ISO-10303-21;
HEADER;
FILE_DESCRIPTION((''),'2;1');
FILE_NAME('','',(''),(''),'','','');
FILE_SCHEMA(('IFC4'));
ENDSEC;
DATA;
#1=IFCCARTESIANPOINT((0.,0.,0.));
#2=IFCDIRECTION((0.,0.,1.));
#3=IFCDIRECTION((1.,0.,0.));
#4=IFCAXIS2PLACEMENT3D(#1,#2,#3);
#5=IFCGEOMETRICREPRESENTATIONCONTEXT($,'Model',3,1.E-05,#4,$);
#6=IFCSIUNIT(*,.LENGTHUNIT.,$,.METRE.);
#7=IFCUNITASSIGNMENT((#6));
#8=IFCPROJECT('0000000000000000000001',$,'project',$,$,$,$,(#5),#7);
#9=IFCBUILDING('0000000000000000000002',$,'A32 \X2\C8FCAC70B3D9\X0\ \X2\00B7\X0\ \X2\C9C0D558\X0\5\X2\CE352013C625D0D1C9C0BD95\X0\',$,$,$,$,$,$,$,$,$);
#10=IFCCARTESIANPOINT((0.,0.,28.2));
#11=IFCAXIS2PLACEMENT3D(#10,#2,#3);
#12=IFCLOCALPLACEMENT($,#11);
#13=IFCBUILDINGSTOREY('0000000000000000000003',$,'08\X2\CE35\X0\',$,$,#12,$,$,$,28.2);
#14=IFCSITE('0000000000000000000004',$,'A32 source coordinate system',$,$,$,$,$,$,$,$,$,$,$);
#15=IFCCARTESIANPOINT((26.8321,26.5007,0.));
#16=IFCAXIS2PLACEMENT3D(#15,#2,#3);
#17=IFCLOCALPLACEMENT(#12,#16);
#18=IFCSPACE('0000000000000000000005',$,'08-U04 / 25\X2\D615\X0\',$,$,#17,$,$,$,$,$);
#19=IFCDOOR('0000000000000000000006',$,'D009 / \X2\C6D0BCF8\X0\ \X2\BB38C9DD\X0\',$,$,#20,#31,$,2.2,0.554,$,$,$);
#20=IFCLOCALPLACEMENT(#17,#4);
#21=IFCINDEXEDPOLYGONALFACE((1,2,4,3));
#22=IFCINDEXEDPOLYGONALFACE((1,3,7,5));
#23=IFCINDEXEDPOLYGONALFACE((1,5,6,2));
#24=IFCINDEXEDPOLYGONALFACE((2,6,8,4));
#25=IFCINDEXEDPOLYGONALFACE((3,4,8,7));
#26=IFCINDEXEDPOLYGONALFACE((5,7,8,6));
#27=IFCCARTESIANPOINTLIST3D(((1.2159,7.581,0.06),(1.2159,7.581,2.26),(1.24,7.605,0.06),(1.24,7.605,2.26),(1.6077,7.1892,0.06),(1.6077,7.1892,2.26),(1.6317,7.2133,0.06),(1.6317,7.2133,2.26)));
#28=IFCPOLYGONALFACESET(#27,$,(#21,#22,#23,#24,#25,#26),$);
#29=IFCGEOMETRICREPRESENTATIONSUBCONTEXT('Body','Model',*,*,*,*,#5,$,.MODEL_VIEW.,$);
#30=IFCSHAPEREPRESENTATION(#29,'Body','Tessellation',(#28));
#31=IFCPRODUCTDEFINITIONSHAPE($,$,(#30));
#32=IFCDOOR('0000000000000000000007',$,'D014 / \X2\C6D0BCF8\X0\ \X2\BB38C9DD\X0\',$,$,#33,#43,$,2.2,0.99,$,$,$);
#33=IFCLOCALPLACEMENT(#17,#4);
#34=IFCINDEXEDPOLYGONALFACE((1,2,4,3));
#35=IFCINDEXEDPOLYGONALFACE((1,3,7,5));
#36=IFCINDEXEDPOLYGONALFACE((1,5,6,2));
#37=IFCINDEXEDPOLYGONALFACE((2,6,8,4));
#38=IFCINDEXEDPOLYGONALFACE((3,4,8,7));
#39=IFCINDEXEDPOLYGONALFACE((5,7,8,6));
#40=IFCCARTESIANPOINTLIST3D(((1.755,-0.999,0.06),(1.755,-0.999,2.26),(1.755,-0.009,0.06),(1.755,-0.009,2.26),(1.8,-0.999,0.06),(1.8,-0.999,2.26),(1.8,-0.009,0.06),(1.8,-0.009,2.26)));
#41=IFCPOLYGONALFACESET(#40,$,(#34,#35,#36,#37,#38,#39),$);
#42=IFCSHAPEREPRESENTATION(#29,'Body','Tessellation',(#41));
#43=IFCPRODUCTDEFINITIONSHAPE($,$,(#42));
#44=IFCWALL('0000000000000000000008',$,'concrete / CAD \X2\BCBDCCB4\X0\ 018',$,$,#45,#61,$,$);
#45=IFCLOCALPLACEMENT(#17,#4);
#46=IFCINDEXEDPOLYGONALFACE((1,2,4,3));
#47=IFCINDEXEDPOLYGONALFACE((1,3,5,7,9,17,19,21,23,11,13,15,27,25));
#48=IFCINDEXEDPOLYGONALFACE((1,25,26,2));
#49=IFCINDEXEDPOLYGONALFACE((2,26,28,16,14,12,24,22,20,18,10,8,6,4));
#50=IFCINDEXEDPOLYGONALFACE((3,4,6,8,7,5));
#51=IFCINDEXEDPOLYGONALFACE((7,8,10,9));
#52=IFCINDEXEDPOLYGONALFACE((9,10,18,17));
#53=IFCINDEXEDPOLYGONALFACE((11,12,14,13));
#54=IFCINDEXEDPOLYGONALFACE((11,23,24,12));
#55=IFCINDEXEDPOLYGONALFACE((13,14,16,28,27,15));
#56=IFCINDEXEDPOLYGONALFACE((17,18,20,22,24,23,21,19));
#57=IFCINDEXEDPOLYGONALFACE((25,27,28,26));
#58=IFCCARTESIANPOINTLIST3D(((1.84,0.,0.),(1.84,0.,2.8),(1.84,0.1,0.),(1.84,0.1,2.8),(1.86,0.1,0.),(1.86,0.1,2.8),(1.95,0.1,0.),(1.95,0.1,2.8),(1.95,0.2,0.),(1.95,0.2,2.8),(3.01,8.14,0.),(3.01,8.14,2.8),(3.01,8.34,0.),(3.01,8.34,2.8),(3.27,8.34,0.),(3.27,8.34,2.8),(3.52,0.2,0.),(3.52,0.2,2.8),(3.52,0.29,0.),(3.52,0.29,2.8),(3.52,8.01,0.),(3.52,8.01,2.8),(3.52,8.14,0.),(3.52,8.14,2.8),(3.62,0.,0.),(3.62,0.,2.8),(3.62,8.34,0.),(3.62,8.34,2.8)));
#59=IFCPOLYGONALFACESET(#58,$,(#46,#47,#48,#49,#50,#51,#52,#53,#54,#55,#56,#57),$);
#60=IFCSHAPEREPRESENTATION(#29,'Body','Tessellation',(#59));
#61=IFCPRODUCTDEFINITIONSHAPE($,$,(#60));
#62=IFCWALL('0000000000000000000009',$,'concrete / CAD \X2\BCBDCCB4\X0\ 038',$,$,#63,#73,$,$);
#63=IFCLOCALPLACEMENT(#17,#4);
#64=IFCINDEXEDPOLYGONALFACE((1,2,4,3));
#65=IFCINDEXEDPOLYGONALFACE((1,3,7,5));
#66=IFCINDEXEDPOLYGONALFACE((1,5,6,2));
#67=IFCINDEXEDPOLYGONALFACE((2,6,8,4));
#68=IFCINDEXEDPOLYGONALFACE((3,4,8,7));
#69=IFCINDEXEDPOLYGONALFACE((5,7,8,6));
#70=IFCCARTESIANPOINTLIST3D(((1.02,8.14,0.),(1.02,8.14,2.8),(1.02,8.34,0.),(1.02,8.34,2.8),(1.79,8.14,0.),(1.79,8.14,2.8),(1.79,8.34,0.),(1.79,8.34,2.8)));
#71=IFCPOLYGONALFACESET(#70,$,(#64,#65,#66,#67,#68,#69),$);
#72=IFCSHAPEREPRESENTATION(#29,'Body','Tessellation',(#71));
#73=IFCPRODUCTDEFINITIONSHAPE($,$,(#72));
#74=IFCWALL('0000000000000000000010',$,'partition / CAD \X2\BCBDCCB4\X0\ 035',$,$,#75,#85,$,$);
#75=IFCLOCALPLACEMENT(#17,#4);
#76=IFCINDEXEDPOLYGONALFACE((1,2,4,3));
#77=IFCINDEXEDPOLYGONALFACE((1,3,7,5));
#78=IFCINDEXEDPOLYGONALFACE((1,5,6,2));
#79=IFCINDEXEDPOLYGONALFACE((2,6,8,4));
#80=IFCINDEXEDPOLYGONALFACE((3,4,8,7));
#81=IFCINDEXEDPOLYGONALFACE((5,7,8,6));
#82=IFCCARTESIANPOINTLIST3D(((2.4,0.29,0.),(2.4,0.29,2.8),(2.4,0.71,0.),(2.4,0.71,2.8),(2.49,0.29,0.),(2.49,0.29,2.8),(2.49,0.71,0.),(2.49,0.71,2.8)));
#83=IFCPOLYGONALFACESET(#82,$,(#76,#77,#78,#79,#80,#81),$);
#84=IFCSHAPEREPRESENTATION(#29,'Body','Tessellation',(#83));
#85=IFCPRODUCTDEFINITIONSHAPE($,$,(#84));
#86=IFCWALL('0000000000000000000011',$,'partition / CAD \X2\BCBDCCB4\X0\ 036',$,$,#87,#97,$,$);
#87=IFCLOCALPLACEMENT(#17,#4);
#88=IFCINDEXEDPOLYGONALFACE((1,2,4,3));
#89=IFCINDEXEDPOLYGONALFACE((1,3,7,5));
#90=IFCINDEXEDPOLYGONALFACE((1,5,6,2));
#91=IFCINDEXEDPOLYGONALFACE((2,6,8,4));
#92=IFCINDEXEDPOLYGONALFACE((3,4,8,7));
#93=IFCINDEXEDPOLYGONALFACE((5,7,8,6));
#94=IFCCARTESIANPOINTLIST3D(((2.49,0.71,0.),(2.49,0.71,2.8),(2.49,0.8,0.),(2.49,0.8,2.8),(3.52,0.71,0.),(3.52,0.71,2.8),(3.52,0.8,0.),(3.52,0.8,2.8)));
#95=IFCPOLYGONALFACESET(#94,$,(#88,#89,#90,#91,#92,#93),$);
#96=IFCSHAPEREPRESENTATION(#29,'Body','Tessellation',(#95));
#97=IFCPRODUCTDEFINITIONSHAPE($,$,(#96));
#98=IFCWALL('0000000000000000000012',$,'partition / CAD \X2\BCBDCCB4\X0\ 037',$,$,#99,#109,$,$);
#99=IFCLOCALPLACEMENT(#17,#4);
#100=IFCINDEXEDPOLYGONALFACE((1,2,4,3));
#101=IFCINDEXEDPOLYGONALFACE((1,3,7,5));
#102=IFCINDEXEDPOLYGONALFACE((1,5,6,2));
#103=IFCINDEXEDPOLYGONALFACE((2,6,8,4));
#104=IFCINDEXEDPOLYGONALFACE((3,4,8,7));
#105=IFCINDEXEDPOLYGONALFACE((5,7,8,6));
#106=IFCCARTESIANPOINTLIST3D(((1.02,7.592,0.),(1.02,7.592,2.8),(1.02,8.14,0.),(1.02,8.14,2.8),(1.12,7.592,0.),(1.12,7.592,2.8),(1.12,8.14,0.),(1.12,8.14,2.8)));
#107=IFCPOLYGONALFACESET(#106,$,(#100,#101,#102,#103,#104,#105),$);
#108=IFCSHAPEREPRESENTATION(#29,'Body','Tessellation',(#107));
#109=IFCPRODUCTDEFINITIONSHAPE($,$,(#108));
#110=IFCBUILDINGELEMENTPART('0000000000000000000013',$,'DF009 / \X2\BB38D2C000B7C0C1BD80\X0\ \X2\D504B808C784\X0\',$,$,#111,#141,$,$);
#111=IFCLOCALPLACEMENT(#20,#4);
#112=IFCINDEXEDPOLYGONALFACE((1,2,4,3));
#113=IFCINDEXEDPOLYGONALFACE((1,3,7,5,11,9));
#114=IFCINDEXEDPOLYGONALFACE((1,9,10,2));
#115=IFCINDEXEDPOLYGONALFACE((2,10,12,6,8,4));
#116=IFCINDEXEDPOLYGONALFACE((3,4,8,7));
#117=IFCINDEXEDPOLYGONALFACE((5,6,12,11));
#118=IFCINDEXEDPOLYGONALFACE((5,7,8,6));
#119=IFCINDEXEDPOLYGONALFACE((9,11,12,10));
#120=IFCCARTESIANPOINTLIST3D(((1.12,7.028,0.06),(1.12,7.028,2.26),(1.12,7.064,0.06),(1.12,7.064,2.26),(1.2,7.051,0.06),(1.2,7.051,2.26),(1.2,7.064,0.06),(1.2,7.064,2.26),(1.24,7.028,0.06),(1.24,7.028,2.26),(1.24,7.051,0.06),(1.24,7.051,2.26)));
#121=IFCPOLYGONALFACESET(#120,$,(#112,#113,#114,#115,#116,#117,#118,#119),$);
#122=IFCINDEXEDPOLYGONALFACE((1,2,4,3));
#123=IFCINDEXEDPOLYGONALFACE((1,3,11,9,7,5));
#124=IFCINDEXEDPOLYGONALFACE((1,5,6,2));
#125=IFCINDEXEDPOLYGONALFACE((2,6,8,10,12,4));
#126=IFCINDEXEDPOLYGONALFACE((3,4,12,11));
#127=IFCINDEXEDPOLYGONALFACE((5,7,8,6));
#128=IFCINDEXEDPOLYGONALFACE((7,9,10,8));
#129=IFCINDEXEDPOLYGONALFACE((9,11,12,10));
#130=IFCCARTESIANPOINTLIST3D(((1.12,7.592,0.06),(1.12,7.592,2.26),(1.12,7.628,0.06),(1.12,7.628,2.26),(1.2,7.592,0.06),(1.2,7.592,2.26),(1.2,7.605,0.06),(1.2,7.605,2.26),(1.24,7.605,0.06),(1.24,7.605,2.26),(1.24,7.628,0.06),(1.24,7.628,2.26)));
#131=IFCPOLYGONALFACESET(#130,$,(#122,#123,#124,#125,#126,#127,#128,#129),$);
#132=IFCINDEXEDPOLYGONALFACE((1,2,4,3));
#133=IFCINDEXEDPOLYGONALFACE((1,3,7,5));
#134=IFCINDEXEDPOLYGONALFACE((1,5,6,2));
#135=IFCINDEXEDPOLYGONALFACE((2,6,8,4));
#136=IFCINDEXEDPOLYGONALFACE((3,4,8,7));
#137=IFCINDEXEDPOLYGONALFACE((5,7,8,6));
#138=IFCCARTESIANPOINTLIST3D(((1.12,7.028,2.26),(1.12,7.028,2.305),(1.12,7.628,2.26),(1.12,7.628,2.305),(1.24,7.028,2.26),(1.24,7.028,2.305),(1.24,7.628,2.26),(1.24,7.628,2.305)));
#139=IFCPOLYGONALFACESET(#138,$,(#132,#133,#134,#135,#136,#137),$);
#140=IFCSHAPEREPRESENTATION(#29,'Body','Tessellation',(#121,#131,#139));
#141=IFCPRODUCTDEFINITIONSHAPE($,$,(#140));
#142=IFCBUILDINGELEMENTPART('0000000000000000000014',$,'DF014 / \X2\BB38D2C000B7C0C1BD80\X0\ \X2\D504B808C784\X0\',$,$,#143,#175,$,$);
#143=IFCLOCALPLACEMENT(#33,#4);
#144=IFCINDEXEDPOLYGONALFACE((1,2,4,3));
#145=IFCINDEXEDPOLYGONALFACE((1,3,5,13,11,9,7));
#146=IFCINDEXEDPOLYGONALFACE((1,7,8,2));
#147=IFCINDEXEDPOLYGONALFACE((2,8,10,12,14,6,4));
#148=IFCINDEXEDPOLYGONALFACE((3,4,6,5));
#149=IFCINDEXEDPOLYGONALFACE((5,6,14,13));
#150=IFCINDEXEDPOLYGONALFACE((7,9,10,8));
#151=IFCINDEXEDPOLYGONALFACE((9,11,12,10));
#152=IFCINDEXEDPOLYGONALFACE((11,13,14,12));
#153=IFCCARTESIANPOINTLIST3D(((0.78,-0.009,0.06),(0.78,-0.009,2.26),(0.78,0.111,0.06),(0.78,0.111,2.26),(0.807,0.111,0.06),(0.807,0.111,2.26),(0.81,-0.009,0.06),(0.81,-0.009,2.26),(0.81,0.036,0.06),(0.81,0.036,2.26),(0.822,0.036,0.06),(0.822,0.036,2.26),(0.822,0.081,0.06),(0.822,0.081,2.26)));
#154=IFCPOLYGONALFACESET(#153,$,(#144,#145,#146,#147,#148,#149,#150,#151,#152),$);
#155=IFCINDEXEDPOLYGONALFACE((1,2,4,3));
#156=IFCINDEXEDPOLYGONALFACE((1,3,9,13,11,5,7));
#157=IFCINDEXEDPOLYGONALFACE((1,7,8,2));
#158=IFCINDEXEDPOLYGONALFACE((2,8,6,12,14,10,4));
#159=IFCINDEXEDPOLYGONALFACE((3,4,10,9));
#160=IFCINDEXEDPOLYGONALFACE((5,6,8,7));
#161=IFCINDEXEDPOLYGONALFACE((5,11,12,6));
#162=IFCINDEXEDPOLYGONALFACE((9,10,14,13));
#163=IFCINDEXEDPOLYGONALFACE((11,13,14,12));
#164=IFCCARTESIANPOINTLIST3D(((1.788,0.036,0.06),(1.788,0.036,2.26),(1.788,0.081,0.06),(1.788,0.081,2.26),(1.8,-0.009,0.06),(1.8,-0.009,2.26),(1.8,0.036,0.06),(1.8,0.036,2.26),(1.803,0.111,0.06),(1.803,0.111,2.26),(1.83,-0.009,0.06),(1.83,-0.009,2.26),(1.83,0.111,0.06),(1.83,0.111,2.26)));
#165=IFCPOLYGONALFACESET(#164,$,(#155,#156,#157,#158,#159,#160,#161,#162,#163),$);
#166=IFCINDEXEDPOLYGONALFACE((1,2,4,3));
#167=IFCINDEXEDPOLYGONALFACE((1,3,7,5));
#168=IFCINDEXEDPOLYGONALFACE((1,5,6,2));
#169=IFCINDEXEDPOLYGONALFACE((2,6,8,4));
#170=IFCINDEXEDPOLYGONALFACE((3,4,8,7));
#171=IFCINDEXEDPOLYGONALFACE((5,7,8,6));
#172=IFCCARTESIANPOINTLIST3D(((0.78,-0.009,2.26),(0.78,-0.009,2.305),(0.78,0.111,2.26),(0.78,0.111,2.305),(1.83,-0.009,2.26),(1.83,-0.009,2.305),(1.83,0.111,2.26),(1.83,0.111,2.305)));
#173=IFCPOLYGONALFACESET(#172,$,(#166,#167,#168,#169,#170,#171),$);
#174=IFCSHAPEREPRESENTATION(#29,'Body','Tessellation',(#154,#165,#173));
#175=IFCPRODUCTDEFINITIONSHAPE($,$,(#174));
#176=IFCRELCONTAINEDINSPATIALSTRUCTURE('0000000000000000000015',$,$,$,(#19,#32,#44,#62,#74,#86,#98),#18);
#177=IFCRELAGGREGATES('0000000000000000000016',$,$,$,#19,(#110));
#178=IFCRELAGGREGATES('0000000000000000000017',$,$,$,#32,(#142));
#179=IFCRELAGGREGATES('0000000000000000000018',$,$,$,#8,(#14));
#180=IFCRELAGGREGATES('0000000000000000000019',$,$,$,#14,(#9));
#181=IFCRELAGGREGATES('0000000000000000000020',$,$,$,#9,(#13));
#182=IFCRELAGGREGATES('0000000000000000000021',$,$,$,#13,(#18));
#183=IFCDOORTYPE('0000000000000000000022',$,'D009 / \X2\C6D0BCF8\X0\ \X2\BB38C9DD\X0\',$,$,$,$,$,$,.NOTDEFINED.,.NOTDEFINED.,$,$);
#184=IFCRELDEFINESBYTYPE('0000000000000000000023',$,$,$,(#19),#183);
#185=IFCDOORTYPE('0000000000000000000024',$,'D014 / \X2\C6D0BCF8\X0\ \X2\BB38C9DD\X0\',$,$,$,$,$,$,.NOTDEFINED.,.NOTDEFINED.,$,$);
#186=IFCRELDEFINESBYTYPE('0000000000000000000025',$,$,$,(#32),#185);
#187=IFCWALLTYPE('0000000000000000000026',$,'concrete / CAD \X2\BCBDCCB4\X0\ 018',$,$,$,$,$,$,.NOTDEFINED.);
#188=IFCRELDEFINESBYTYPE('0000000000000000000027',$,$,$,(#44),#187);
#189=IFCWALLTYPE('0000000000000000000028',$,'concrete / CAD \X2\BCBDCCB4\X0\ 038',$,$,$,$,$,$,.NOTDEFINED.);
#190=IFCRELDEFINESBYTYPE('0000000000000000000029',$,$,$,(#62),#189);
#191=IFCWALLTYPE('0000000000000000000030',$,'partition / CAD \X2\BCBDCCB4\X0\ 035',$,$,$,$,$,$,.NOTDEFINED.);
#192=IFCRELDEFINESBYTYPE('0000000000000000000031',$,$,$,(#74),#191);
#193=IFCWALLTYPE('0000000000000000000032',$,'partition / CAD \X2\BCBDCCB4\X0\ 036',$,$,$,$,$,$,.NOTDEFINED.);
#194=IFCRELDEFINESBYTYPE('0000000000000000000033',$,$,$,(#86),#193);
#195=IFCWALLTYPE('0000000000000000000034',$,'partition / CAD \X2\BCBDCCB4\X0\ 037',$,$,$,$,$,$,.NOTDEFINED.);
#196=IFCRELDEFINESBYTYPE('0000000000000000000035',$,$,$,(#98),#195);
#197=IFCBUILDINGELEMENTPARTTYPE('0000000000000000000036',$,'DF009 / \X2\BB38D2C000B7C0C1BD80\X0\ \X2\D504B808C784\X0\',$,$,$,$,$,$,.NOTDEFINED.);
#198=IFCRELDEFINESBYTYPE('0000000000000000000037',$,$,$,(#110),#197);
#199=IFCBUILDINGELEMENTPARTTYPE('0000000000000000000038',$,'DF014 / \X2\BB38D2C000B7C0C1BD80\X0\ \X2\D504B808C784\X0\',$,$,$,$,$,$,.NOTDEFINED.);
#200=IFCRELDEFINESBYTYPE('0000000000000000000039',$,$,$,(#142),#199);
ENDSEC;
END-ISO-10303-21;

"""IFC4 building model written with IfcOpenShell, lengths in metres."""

from ifc_helpers import new_model, si_unit, frame, origin, origin_with_axes, place, context, subcontext, project, spatial, polyline, outline, extrude, source, transform, mapped, type_object, type_shapes, element, aggregate, save


model = new_model("IFC4")

# Units and contexts
model_context = context("Model", 3, precision=1e-05, world=origin_with_axes())
body_context = subcontext(model_context, "Body", "Model", "MODEL_VIEW")
ifc_project = project(units=[si_unit("LENGTHUNIT", "METRE")], contexts=[model_context])

# Site, building, storey, space
storey_placement = place(None, frame((0.0, 0.0, 28.2), z_axis=(0.0, 0.0, 1.0), x_axis=(1.0, 0.0, 0.0)))
space_placement = place(storey_placement, frame((26.8321, 26.5007, 0.0), z_axis=(0.0, 0.0, 1.0), x_axis=(1.0, 0.0, 0.0)))
site = spatial("IfcSite", under=ifc_project, Name="A32 source coordinate system")
building = spatial("IfcBuilding", under=site, Name="A32 주거동 · 지하5층–옥탑지붕")
storey = spatial("IfcBuildingStorey", under=building, at=storey_placement, Name="08층", Elevation=28.2)
space = spatial("IfcSpace", under=storey, at=space_placement, Name="08-U04 / 25형")

# Doors
door_type_1 = type_object("IfcDoorType", Name="D009 / 원본 문짝", OperationType="NOTDEFINED", PredefinedType="NOTDEFINED")
shared_shape_1 = source(origin(), body_context, "Body", "SweptSolid", [
    extrude(outline(polyline([(1.24, 7.605), (1.6317, 7.2133), (1.6077, 7.1892), (1.2159, 7.581), (1.24, 7.605)])), frame((0.0, 0.0, 0.06)), (0.0, 0.0, 1.0), 2.2),
])
type_shapes(door_type_1, [shared_shape_1])
door_1_placement = place(space_placement, origin_with_axes())
door_1 = element("IfcDoor", 1, at=door_1_placement, inside=space, type_object=door_type_1, Name="D009 / 원본 문짝", OverallHeight=2.2, OverallWidth=0.554, context=body_context, shape_type="MappedRepresentation", body=[
    mapped(shared_shape_1, transform((0.0, 0.0, 0.0), scale=1.0)),
])
door_type_2 = type_object("IfcDoorType", Name="D014 / 원본 문짝", OperationType="NOTDEFINED", PredefinedType="NOTDEFINED")
shared_shape_2 = source(origin(), body_context, "Body", "SweptSolid", [
    extrude(outline(polyline([(1.8, -0.009), (1.8, -0.999), (1.755, -0.999), (1.755, -0.009), (1.8, -0.009)])), frame((0.0, 0.0, 0.06)), (0.0, 0.0, 1.0), 2.2),
])
type_shapes(door_type_2, [shared_shape_2])
door_2_placement = place(space_placement, origin_with_axes())
door_2 = element("IfcDoor", 2, at=door_2_placement, inside=space, type_object=door_type_2, Name="D014 / 원본 문짝", OverallHeight=2.2, OverallWidth=0.99, context=body_context, shape_type="MappedRepresentation", body=[
    mapped(shared_shape_2, transform((0.0, 0.0, 0.0), scale=1.0)),
])

# Walls
wall_type_1 = type_object("IfcWallType", Name="concrete / CAD 벽체 018", PredefinedType="NOTDEFINED")
shared_shape_3 = source(origin(), body_context, "Body", "SweptSolid", [
    extrude(outline(polyline([(3.27, 8.34), (3.27, 8.34), (3.62, 8.34), (3.62, 0.0), (1.84, 0.0), (1.84, 0.1), (1.86, 0.1), (1.95, 0.1), (1.95, 0.2), (3.52, 0.2), (3.52, 0.29), (3.52, 8.01), (3.52, 8.14), (3.01, 8.14), (3.01, 8.34), (3.27, 8.34)])), origin(), (0.0, 0.0, 1.0), 2.8),
])
type_shapes(wall_type_1, [shared_shape_3])
wall_1_placement = place(space_placement, origin_with_axes())
element("IfcWall", 3, at=wall_1_placement, inside=space, type_object=wall_type_1, Name="concrete / CAD 벽체 018", context=body_context, shape_type="MappedRepresentation", body=[
    mapped(shared_shape_3, transform((0.0, 0.0, 0.0), scale=1.0)),
])
wall_type_2 = type_object("IfcWallType", Name="concrete / CAD 벽체 038", PredefinedType="NOTDEFINED")
shared_shape_4 = source(origin(), body_context, "Body", "SweptSolid", [
    extrude(outline(polyline([(1.02, 8.14), (1.02, 8.34), (1.79, 8.34), (1.79, 8.14), (1.02, 8.14)])), origin(), (0.0, 0.0, 1.0), 2.8),
])
type_shapes(wall_type_2, [shared_shape_4])
wall_2_placement = place(space_placement, origin_with_axes())
element("IfcWall", 4, at=wall_2_placement, inside=space, type_object=wall_type_2, Name="concrete / CAD 벽체 038", context=body_context, shape_type="MappedRepresentation", body=[
    mapped(shared_shape_4, transform((0.0, 0.0, 0.0), scale=1.0)),
])
wall_type_3 = type_object("IfcWallType", Name="partition / CAD 벽체 035", PredefinedType="NOTDEFINED")
shared_shape_5 = source(origin(), body_context, "Body", "SweptSolid", [
    extrude(outline(polyline([(2.49, 0.71), (2.49, 0.29), (2.4, 0.29), (2.4, 0.71), (2.49, 0.71)])), origin(), (0.0, 0.0, 1.0), 2.8),
])
type_shapes(wall_type_3, [shared_shape_5])
wall_3_placement = place(space_placement, origin_with_axes())
element("IfcWall", 5, at=wall_3_placement, inside=space, type_object=wall_type_3, Name="partition / CAD 벽체 035", context=body_context, shape_type="MappedRepresentation", body=[
    mapped(shared_shape_5, transform((0.0, 0.0, 0.0), scale=1.0)),
])
wall_type_4 = type_object("IfcWallType", Name="partition / CAD 벽체 036", PredefinedType="NOTDEFINED")
shared_shape_6 = source(origin(), body_context, "Body", "SweptSolid", [
    extrude(outline(polyline([(2.49, 0.8), (3.52, 0.8), (3.52, 0.71), (2.49, 0.71), (2.49, 0.8)])), origin(), (0.0, 0.0, 1.0), 2.8),
])
type_shapes(wall_type_4, [shared_shape_6])
wall_4_placement = place(space_placement, origin_with_axes())
element("IfcWall", 6, at=wall_4_placement, inside=space, type_object=wall_type_4, Name="partition / CAD 벽체 036", context=body_context, shape_type="MappedRepresentation", body=[
    mapped(shared_shape_6, transform((0.0, 0.0, 0.0), scale=1.0)),
])
wall_type_5 = type_object("IfcWallType", Name="partition / CAD 벽체 037", PredefinedType="NOTDEFINED")
shared_shape_7 = source(origin(), body_context, "Body", "SweptSolid", [
    extrude(outline(polyline([(1.02, 7.592), (1.02, 8.14), (1.12, 8.14), (1.12, 7.592), (1.02, 7.592)])), origin(), (0.0, 0.0, 1.0), 2.8),
])
type_shapes(wall_type_5, [shared_shape_7])
wall_5_placement = place(space_placement, origin_with_axes())
element("IfcWall", 7, at=wall_5_placement, inside=space, type_object=wall_type_5, Name="partition / CAD 벽체 037", context=body_context, shape_type="MappedRepresentation", body=[
    mapped(shared_shape_7, transform((0.0, 0.0, 0.0), scale=1.0)),
])

# Building element parts
building_element_part_type_1 = type_object("IfcBuildingElementPartType", Name="DF009 / 문틀·상부 프레임", PredefinedType="NOTDEFINED")
shared_shape_8 = source(origin(), body_context, "Body", "SweptSolid", [
    extrude(outline(polyline([(1.12, 7.064), (1.2, 7.064), (1.2, 7.051), (1.24, 7.051), (1.24, 7.028), (1.12, 7.028), (1.12, 7.064)])), frame((0.0, 0.0, 0.06)), (0.0, 0.0, 1.0), 2.2),
    extrude(outline(polyline([(1.24, 7.628), (1.24, 7.605), (1.2, 7.605), (1.2, 7.592), (1.12, 7.592), (1.12, 7.628), (1.24, 7.628)])), frame((0.0, 0.0, 0.06)), (0.0, 0.0, 1.0), 2.2),
    extrude(outline(polyline([(1.12, 7.028), (1.12, 7.628), (1.24, 7.628), (1.24, 7.028), (1.12, 7.028)])), frame((0.0, 0.0, 2.26)), (0.0, 0.0, 1.0), 0.045),
])
type_shapes(building_element_part_type_1, [shared_shape_8])
building_element_part_1_placement = place(door_1_placement, origin_with_axes())
building_element_part_1 = element("IfcBuildingElementPart", 8, at=building_element_part_1_placement, type_object=building_element_part_type_1, Name="DF009 / 문틀·상부 프레임", context=body_context, shape_type="MappedRepresentation", body=[
    mapped(shared_shape_8, transform((0.0, 0.0, 0.0), scale=1.0)),
])
aggregate(door_1, [building_element_part_1])
building_element_part_type_2 = type_object("IfcBuildingElementPartType", Name="DF014 / 문틀·상부 프레임", PredefinedType="NOTDEFINED")
shared_shape_9 = source(origin(), body_context, "Body", "SweptSolid", [
    extrude(outline(polyline([(0.78, 0.111), (0.807, 0.111), (0.822, 0.081), (0.822, 0.036), (0.81, 0.036), (0.81, -0.009), (0.78, -0.009), (0.78, 0.111)])), frame((0.0, 0.0, 0.06)), (0.0, 0.0, 1.0), 2.2),
    extrude(outline(polyline([(1.8, -0.009), (1.8, 0.036), (1.788, 0.036), (1.788, 0.081), (1.803, 0.111), (1.83, 0.111), (1.83, -0.009), (1.8, -0.009)])), frame((0.0, 0.0, 0.06)), (0.0, 0.0, 1.0), 2.2),
    extrude(outline(polyline([(0.78, -0.009), (0.78, 0.111), (1.83, 0.111), (1.83, -0.009), (0.78, -0.009)])), frame((0.0, 0.0, 2.26)), (0.0, 0.0, 1.0), 0.045),
])
type_shapes(building_element_part_type_2, [shared_shape_9])
building_element_part_2_placement = place(door_2_placement, origin_with_axes())
building_element_part_2 = element("IfcBuildingElementPart", 9, at=building_element_part_2_placement, type_object=building_element_part_type_2, Name="DF014 / 문틀·상부 프레임", context=body_context, shape_type="MappedRepresentation", body=[
    mapped(shared_shape_9, transform((0.0, 0.0, 0.0), scale=1.0)),
])
aggregate(door_2, [building_element_part_2])

save(model, "model.ifc")
